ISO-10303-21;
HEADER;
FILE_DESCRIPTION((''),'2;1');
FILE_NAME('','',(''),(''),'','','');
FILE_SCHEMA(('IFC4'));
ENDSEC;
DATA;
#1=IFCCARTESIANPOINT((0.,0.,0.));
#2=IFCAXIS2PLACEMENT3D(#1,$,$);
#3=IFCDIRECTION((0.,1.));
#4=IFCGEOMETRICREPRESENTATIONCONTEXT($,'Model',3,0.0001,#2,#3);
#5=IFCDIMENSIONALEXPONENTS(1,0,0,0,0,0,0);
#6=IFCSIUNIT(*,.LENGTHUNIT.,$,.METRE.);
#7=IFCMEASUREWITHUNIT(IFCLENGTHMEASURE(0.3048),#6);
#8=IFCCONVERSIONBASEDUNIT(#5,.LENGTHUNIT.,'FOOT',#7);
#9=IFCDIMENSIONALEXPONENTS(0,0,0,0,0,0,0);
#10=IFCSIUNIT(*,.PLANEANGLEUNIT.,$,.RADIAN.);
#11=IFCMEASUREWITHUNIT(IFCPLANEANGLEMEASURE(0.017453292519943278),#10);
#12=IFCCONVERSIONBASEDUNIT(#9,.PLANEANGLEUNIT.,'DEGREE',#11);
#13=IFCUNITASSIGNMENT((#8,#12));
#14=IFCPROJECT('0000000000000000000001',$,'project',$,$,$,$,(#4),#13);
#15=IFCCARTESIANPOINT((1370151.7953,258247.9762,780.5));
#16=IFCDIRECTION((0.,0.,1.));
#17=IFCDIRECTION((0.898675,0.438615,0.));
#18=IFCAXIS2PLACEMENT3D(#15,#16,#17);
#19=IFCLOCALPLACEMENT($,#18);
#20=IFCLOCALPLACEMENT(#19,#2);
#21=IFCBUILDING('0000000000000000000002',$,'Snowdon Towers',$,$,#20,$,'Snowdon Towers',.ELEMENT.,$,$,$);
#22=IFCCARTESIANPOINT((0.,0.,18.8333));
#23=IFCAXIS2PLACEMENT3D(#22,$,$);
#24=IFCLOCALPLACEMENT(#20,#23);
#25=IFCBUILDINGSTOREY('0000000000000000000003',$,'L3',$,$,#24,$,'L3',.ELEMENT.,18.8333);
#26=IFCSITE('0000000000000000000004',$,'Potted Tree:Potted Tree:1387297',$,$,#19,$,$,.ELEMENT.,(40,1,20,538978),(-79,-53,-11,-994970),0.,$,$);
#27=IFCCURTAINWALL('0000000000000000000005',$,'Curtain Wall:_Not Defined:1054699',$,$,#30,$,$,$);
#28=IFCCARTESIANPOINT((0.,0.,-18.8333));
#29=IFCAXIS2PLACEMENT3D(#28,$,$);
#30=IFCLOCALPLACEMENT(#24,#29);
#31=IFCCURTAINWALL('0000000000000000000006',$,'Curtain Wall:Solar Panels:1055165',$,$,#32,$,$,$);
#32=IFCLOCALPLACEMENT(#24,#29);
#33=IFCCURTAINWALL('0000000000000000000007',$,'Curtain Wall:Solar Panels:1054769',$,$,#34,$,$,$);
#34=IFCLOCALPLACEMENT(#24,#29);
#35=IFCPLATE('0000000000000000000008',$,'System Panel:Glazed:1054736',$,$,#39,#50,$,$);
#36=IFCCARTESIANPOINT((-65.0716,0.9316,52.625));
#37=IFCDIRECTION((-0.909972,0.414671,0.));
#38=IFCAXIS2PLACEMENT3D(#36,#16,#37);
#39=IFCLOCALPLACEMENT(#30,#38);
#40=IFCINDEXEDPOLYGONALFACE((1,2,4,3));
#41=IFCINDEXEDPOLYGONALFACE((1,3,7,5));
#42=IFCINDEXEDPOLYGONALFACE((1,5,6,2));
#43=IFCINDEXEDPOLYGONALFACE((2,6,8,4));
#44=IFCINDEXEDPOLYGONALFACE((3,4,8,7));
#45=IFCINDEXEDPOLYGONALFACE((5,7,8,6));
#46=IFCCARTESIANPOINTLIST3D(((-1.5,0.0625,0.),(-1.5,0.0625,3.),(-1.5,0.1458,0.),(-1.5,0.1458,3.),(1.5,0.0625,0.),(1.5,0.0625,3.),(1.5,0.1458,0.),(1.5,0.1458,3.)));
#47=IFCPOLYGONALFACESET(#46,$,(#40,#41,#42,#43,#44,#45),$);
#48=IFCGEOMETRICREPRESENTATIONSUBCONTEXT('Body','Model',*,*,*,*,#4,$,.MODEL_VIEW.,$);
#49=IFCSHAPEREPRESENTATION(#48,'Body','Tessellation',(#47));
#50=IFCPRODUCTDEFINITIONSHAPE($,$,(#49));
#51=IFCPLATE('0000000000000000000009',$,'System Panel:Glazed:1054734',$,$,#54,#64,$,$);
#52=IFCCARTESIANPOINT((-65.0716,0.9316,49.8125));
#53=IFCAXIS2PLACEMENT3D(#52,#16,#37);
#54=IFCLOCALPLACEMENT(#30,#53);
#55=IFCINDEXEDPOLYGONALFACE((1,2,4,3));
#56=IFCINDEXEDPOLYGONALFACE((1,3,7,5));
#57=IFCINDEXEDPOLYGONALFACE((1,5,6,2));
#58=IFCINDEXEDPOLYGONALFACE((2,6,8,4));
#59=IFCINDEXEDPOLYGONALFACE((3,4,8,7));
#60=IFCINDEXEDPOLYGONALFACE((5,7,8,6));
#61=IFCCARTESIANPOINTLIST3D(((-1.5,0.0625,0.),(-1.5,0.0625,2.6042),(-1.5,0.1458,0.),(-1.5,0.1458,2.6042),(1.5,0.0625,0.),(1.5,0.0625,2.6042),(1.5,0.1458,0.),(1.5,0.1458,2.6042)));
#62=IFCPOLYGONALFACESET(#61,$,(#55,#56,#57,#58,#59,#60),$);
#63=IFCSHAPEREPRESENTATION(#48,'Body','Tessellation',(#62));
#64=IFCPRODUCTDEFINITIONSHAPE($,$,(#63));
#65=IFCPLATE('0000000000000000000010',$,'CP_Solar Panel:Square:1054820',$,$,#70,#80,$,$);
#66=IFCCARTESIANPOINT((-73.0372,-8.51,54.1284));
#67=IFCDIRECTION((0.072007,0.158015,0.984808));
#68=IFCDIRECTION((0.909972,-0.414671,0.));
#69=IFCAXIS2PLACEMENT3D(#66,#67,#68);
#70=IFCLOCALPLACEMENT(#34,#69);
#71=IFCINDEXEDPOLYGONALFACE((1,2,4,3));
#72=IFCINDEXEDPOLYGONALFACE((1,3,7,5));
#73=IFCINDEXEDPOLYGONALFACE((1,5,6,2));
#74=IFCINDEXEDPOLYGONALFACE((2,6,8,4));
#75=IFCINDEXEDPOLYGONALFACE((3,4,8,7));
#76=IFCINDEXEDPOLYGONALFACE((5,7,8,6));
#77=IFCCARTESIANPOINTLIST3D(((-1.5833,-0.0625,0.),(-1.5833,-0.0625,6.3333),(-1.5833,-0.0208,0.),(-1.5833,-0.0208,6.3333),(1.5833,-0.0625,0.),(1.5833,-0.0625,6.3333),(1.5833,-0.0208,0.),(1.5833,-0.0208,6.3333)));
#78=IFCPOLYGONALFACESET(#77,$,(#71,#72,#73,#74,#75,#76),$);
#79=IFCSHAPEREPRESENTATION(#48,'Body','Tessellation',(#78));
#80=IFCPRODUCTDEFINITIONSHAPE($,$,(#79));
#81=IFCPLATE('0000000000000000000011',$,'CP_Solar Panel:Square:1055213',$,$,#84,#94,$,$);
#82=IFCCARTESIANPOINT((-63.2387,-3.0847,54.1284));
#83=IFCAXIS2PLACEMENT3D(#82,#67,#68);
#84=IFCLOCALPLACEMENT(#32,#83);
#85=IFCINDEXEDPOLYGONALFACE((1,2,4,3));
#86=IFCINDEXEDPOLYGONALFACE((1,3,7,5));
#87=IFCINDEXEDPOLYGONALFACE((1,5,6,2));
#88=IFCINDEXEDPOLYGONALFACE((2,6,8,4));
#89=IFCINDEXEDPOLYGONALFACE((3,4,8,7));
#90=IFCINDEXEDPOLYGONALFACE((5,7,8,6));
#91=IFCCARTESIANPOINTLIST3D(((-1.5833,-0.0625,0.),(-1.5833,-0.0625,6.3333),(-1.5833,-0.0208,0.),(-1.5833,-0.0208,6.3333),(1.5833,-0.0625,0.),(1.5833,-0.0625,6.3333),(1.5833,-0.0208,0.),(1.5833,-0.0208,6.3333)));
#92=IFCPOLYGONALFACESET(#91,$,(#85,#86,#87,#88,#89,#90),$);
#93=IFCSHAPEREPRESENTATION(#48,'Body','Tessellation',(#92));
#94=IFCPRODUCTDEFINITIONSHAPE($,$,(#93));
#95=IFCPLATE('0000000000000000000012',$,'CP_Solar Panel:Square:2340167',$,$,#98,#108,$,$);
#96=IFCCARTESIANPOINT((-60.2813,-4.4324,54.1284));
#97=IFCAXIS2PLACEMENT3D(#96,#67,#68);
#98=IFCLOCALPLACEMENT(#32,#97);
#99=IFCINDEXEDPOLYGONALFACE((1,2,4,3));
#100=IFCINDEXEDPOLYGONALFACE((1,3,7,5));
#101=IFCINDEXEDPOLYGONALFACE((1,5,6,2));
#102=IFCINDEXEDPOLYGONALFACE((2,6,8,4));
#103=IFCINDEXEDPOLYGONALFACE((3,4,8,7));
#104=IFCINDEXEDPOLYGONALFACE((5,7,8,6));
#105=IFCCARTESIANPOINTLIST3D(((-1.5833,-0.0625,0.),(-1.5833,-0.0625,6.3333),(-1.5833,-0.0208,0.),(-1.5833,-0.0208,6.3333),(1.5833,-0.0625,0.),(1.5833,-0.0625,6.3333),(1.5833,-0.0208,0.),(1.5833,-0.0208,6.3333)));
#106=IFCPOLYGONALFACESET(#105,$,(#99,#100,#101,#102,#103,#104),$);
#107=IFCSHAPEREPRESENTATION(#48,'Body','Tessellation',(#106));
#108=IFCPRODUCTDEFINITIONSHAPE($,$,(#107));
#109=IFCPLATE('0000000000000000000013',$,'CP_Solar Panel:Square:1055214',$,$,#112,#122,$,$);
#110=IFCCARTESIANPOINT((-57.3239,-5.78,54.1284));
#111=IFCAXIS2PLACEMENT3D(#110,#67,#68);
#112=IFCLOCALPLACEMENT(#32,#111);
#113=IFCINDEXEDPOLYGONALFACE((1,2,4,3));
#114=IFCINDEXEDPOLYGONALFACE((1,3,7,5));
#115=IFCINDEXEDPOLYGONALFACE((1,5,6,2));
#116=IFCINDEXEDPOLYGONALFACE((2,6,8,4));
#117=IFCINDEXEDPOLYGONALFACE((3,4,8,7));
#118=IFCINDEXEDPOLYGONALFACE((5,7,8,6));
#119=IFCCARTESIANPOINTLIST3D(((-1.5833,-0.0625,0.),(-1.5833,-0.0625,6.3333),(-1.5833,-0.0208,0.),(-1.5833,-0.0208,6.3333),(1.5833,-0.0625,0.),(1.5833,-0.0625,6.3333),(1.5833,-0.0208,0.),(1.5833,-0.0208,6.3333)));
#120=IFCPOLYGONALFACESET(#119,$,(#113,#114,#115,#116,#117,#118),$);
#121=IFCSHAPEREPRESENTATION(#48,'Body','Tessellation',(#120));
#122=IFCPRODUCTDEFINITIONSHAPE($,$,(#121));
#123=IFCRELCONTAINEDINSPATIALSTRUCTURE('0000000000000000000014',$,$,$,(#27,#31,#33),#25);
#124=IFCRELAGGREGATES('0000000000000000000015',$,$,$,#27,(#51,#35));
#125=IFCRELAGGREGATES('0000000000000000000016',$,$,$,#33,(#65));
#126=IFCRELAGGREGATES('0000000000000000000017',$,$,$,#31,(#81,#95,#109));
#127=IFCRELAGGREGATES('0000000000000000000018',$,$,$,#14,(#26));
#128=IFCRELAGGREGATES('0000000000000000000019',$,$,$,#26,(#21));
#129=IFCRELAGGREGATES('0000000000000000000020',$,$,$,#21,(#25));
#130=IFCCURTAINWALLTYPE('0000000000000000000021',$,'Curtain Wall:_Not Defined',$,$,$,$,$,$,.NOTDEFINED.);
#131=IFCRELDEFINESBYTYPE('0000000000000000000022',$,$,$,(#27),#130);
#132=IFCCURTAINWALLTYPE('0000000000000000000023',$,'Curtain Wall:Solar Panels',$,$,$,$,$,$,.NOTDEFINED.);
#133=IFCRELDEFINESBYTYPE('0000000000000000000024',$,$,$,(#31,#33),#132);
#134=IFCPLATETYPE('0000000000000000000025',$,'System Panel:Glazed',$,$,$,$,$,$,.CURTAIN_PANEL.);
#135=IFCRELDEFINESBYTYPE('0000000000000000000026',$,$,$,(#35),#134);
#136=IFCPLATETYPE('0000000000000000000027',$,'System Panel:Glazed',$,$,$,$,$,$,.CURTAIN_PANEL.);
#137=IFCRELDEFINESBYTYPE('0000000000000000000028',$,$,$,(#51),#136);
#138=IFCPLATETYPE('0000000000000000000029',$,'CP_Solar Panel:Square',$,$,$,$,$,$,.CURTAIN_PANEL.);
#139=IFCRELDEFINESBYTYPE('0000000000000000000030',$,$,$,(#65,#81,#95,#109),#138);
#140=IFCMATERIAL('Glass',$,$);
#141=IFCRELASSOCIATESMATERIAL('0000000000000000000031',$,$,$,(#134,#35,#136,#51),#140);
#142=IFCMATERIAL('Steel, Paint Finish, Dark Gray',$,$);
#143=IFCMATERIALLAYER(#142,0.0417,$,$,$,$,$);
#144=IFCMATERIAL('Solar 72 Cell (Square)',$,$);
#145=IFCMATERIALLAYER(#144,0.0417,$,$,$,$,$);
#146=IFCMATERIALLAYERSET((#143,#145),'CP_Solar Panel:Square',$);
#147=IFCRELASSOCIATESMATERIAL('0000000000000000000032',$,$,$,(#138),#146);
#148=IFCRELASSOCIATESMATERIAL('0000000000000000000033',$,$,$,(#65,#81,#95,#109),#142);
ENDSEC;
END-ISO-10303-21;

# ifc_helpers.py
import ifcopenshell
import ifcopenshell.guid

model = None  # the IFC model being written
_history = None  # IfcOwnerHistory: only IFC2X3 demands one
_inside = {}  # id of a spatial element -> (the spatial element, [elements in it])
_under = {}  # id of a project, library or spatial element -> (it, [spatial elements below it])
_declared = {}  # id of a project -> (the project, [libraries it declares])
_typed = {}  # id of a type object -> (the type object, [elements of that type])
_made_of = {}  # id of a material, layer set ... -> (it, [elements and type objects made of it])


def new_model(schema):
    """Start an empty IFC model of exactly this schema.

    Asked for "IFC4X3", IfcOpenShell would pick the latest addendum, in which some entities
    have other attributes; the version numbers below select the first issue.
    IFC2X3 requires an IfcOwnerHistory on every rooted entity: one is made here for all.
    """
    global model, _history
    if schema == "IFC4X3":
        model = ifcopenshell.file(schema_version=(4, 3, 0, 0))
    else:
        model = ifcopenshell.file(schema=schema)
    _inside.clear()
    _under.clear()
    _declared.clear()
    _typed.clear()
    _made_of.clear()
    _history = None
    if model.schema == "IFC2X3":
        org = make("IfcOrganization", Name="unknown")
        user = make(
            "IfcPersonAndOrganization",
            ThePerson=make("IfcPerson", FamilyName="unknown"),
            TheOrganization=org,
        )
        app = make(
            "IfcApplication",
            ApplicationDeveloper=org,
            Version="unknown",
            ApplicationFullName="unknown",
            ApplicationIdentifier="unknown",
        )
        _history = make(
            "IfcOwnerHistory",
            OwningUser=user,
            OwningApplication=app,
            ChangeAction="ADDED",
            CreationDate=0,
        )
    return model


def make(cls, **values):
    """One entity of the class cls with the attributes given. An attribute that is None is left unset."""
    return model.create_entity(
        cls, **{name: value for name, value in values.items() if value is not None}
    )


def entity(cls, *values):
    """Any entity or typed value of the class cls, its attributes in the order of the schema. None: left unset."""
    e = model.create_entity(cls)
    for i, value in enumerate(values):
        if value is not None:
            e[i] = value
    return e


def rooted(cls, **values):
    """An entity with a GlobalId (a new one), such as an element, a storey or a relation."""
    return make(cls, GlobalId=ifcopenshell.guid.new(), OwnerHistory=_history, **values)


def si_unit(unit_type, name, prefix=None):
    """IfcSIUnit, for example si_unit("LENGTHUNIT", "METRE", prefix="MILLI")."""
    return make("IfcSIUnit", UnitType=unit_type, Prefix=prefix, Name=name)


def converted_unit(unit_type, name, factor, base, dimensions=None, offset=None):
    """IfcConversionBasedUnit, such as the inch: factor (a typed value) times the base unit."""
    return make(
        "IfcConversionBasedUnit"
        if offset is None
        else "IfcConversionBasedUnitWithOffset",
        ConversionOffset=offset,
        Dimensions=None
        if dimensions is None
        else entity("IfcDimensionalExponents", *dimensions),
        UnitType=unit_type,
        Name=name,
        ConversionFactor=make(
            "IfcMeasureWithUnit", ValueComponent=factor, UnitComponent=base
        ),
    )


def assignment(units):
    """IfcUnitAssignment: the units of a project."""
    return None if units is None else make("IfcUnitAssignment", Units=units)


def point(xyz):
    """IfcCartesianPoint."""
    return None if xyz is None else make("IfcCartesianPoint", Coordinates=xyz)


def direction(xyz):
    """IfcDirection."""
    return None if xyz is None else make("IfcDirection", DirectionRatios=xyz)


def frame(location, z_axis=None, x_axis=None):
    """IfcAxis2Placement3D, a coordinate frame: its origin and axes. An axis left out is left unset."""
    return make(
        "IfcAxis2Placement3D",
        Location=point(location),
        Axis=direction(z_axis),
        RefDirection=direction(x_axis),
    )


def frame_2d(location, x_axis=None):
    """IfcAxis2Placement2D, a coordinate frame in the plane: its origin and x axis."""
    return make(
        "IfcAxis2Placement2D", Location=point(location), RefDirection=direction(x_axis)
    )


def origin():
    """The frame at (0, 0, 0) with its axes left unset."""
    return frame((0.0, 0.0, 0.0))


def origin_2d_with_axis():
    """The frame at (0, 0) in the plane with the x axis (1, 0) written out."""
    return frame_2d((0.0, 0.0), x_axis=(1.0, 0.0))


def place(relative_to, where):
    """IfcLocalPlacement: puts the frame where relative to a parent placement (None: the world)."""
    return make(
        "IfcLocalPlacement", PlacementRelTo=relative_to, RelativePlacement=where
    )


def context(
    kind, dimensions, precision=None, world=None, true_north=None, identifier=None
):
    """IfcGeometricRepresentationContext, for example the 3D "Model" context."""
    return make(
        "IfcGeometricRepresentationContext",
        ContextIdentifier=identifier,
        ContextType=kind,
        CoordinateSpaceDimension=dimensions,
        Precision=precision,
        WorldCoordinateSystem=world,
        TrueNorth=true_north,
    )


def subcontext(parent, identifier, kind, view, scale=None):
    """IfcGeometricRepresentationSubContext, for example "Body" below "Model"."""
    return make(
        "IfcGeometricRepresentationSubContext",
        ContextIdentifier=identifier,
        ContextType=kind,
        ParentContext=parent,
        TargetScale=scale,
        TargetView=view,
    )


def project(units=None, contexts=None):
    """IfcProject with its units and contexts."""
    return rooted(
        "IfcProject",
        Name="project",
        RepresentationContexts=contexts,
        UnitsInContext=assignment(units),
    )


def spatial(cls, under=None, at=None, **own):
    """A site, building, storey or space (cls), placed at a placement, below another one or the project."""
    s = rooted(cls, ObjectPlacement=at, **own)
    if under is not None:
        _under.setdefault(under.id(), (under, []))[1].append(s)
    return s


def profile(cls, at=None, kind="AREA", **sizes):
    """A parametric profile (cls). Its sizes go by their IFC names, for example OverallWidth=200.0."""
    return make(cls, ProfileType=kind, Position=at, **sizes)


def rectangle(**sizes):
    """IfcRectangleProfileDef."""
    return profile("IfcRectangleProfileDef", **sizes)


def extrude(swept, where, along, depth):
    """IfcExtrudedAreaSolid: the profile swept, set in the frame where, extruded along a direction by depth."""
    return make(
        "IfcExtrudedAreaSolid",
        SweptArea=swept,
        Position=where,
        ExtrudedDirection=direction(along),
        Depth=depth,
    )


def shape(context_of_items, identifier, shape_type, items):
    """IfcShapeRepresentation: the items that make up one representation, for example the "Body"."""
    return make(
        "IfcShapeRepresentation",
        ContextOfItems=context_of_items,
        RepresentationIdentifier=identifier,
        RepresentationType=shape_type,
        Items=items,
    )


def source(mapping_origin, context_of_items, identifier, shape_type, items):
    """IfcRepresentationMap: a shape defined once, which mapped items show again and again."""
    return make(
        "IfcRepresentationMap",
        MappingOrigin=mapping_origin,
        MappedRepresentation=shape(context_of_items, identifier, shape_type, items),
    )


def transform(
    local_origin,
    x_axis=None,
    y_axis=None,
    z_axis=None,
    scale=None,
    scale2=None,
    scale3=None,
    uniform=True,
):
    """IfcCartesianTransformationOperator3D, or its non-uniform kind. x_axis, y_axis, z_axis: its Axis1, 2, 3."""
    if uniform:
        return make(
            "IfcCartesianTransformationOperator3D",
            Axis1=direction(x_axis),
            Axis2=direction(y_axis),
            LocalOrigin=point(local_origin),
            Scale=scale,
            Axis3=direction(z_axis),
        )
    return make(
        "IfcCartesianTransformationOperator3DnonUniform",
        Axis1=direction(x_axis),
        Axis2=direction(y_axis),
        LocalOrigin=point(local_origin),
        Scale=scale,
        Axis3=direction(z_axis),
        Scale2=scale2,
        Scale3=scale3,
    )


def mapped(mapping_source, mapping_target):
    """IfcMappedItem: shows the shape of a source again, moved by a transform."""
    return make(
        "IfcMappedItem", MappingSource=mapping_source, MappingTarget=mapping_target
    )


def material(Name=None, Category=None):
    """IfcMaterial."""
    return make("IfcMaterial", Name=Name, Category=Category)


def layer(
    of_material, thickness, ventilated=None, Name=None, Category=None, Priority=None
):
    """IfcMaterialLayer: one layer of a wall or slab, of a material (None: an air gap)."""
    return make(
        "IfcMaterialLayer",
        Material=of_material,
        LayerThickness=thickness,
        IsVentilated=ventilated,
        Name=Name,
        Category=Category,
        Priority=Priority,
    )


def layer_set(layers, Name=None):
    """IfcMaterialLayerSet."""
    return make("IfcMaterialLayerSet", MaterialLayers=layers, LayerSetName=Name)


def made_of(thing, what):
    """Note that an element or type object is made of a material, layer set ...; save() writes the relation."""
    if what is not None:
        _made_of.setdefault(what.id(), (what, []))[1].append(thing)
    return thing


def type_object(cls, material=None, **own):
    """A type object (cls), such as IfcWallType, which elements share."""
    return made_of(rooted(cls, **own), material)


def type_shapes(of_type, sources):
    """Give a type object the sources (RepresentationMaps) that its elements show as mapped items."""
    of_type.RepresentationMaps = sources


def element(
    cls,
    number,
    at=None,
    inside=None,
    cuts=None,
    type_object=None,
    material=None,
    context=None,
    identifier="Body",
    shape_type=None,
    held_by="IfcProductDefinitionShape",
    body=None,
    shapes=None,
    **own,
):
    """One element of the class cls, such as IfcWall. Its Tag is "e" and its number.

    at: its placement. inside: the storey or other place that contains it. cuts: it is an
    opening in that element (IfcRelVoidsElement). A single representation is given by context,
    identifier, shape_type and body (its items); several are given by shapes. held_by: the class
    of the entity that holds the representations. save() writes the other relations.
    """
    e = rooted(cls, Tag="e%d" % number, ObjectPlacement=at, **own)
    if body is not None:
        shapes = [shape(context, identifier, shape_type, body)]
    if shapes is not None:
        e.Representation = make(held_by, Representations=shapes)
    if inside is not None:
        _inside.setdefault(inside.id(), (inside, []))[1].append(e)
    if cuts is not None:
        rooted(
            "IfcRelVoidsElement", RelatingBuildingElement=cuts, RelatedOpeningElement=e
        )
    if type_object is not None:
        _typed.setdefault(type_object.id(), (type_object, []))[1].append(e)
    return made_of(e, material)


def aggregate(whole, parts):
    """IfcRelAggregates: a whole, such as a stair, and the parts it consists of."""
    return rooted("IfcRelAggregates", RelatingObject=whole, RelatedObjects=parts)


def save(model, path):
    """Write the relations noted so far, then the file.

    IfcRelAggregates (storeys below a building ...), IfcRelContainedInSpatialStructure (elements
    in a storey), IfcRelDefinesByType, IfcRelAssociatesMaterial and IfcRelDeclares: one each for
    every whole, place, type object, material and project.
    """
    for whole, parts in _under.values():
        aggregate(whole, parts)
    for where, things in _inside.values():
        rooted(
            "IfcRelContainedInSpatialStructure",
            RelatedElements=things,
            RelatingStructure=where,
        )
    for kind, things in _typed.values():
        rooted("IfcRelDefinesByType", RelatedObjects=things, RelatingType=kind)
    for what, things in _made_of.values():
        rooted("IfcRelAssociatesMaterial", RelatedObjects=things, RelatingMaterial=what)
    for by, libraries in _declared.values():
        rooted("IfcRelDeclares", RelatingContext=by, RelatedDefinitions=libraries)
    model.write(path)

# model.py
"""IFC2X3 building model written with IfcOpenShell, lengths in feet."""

from ifc_helpers import new_model, entity, si_unit, converted_unit, direction, frame, frame_2d, origin, origin_2d_with_axis, place, context, subcontext, project, spatial, rectangle, extrude, source, transform, mapped, material, layer, layer_set, type_object, type_shapes, element, aggregate, save


model = new_model("IFC2X3")

# Units and contexts
model_context = context("Model", 3, precision=0.0001, world=origin(), true_north=direction((0.0, 1.0)))
body_context = subcontext(model_context, "Body", "Model", "MODEL_VIEW")
ifc_project = project(units=[converted_unit("LENGTHUNIT", "FOOT", entity("IfcLengthMeasure", 0.3048), si_unit("LENGTHUNIT", "METRE"), dimensions=[1, 0, 0, 0, 0, 0, 0]), converted_unit("PLANEANGLEUNIT", "DEGREE", entity("IfcPlaneAngleMeasure", 0.017453292519943278), si_unit("PLANEANGLEUNIT", "RADIAN"), dimensions=[0, 0, 0, 0, 0, 0, 0])], contexts=[model_context])

# Site, building, storey
site_placement = place(None, frame((1370151.7953, 258247.9762, 780.5), z_axis=(0.0, 0.0, 1.0), x_axis=(0.898675, 0.438615, 0.0)))
site = spatial("IfcSite", under=ifc_project, at=site_placement, Name="Potted Tree:Potted Tree:1387297", CompositionType="ELEMENT", RefLatitude=(40, 1, 20, 538978), RefLongitude=(-79, -53, -11, -994970), RefElevation=0.0)
building_placement = place(site_placement, origin())
building = spatial("IfcBuilding", under=site, at=building_placement, Name="Snowdon Towers", LongName="Snowdon Towers", CompositionType="ELEMENT")
storey_placement = place(building_placement, frame((0.0, 0.0, 18.8333)))
storey = spatial("IfcBuildingStorey", under=building, at=storey_placement, Name="L3", LongName="L3", CompositionType="ELEMENT", Elevation=18.8333)

# Curtain wall
curtain_wall_type_1 = type_object("IfcCurtainWallType", Name="Curtain Wall:_Not Defined", PredefinedType="NOTDEFINED")
curtain_wall_1_placement = place(storey_placement, frame((0.0, 0.0, -18.8333)))
curtain_wall_1 = element("IfcCurtainWall", 1, at=curtain_wall_1_placement, inside=storey, type_object=curtain_wall_type_1, Name="Curtain Wall:_Not Defined:1054699")

# Curtain walls
curtain_wall_type_2 = type_object("IfcCurtainWallType", Name="Curtain Wall:Solar Panels", PredefinedType="NOTDEFINED")
curtain_wall_2_placement = place(storey_placement, frame((0.0, 0.0, -18.8333)))
curtain_wall_2 = element("IfcCurtainWall", 2, at=curtain_wall_2_placement, inside=storey, type_object=curtain_wall_type_2, Name="Curtain Wall:Solar Panels:1055165")
curtain_wall_3_placement = place(storey_placement, frame((0.0, 0.0, -18.8333)))
curtain_wall_3 = element("IfcCurtainWall", 3, at=curtain_wall_3_placement, inside=storey, type_object=curtain_wall_type_2, Name="Curtain Wall:Solar Panels:1054769")

# Shared definitions
ifc_material_1 = material(Name="Steel, Paint Finish, Dark Gray")

# Plates
ifc_material_2 = material(Name="Glass")
plate_type_1 = type_object("IfcPlateType", Name="System Panel:Glazed", PredefinedType="CURTAIN_PANEL", material=ifc_material_2)
shared_shape_1 = source(origin(), body_context, "Body", "SweptSolid", [
    extrude(rectangle(XDim=0.0833, YDim=3.0, at=frame_2d((0.0, 0.0), x_axis=(1.0, 0.0))), frame((0.0, 0.1042, 0.0), z_axis=(0.0, 0.0, 1.0), x_axis=(0.0, 1.0, 0.0)), (0.0, 0.0, 1.0), 3.0),
])
type_shapes(plate_type_1, [shared_shape_1])
plate_1_placement = place(curtain_wall_1_placement, frame((-65.0716, 0.9316, 52.625), z_axis=(0.0, 0.0, 1.0), x_axis=(-0.909972, 0.414671, 0.0)))
plate_1 = element("IfcPlate", 4, at=plate_1_placement, type_object=plate_type_1, material=ifc_material_2, Name="System Panel:Glazed:1054736", context=body_context, shape_type="MappedRepresentation", body=[
    mapped(shared_shape_1, transform((0.0, 0.0, 0.0), scale=1.0)),
])
plate_type_2 = type_object("IfcPlateType", Name="System Panel:Glazed", PredefinedType="CURTAIN_PANEL", material=ifc_material_2)
shared_shape_2 = source(origin(), body_context, "Body", "SweptSolid", [
    extrude(rectangle(XDim=0.0833, YDim=3.0, at=frame_2d((0.0, 0.0), x_axis=(1.0, 0.0))), frame((0.0, 0.1042, 0.0), z_axis=(0.0, 0.0, 1.0), x_axis=(0.0, 1.0, 0.0)), (0.0, 0.0, 1.0), 2.6042),
])
type_shapes(plate_type_2, [shared_shape_2])
plate_2_placement = place(curtain_wall_1_placement, frame((-65.0716, 0.9316, 49.8125), z_axis=(0.0, 0.0, 1.0), x_axis=(-0.909972, 0.414671, 0.0)))
plate_2 = element("IfcPlate", 5, at=plate_2_placement, type_object=plate_type_2, material=ifc_material_2, Name="System Panel:Glazed:1054734", context=body_context, shape_type="MappedRepresentation", body=[
    mapped(shared_shape_2, transform((0.0, 0.0, 0.0), scale=1.0)),
])
aggregate(curtain_wall_1, [plate_2, plate_1])
ifc_layer_1 = layer(ifc_material_1, 0.0417)
ifc_material_3 = material(Name="Solar 72 Cell (Square)")
ifc_layer_2 = layer(ifc_material_3, 0.0417)
ifc_layer_set = layer_set([ifc_layer_1, ifc_layer_2], Name="CP_Solar Panel:Square")
plate_type_3 = type_object("IfcPlateType", Name="CP_Solar Panel:Square", PredefinedType="CURTAIN_PANEL", material=ifc_layer_set)
shared_shape_3 = source(origin(), body_context, "Body", "SweptSolid", [
    extrude(rectangle(XDim=3.1667, YDim=0.0417, at=origin_2d_with_axis()), frame((0.0, -0.0417, 0.0)), (0.0, 0.0, 1.0), 6.3333),
])
type_shapes(plate_type_3, [shared_shape_3])
plate_3_placement = place(curtain_wall_3_placement, frame((-73.0372, -8.51, 54.1284), z_axis=(0.072007, 0.158015, 0.984808), x_axis=(0.909972, -0.414671, 0.0)))
plate_3 = element("IfcPlate", 6, at=plate_3_placement, type_object=plate_type_3, material=ifc_material_1, Name="CP_Solar Panel:Square:1054820", context=body_context, shape_type="MappedRepresentation", body=[
    mapped(shared_shape_3, transform((0.0, 0.0, 0.0), scale=1.0)),
])
aggregate(curtain_wall_3, [plate_3])
plate_4_placement = place(curtain_wall_2_placement, frame((-63.2387, -3.0847, 54.1284), z_axis=(0.072007, 0.158015, 0.984808), x_axis=(0.909972, -0.414671, 0.0)))
plate_4 = element("IfcPlate", 7, at=plate_4_placement, type_object=plate_type_3, material=ifc_material_1, Name="CP_Solar Panel:Square:1055213", context=body_context, shape_type="MappedRepresentation", body=[
    mapped(shared_shape_3, transform((0.0, 0.0, 0.0), scale=1.0)),
])
plate_5_placement = place(curtain_wall_2_placement, frame((-60.2813, -4.4324, 54.1284), z_axis=(0.072007, 0.158015, 0.984808), x_axis=(0.909972, -0.414671, 0.0)))
plate_5 = element("IfcPlate", 8, at=plate_5_placement, type_object=plate_type_3, material=ifc_material_1, Name="CP_Solar Panel:Square:2340167", context=body_context, shape_type="MappedRepresentation", body=[
    mapped(shared_shape_3, transform((0.0, 0.0, 0.0), scale=1.0)),
])
plate_6_placement = place(curtain_wall_2_placement, frame((-57.3239, -5.78, 54.1284), z_axis=(0.072007, 0.158015, 0.984808), x_axis=(0.909972, -0.414671, 0.0)))
plate_6 = element("IfcPlate", 9, at=plate_6_placement, type_object=plate_type_3, material=ifc_material_1, Name="CP_Solar Panel:Square:1055214", context=body_context, shape_type="MappedRepresentation", body=[
    mapped(shared_shape_3, transform((0.0, 0.0, 0.0), scale=1.0)),
])
aggregate(curtain_wall_2, [plate_4, plate_5, plate_6])

save(model, "model.ifc")
